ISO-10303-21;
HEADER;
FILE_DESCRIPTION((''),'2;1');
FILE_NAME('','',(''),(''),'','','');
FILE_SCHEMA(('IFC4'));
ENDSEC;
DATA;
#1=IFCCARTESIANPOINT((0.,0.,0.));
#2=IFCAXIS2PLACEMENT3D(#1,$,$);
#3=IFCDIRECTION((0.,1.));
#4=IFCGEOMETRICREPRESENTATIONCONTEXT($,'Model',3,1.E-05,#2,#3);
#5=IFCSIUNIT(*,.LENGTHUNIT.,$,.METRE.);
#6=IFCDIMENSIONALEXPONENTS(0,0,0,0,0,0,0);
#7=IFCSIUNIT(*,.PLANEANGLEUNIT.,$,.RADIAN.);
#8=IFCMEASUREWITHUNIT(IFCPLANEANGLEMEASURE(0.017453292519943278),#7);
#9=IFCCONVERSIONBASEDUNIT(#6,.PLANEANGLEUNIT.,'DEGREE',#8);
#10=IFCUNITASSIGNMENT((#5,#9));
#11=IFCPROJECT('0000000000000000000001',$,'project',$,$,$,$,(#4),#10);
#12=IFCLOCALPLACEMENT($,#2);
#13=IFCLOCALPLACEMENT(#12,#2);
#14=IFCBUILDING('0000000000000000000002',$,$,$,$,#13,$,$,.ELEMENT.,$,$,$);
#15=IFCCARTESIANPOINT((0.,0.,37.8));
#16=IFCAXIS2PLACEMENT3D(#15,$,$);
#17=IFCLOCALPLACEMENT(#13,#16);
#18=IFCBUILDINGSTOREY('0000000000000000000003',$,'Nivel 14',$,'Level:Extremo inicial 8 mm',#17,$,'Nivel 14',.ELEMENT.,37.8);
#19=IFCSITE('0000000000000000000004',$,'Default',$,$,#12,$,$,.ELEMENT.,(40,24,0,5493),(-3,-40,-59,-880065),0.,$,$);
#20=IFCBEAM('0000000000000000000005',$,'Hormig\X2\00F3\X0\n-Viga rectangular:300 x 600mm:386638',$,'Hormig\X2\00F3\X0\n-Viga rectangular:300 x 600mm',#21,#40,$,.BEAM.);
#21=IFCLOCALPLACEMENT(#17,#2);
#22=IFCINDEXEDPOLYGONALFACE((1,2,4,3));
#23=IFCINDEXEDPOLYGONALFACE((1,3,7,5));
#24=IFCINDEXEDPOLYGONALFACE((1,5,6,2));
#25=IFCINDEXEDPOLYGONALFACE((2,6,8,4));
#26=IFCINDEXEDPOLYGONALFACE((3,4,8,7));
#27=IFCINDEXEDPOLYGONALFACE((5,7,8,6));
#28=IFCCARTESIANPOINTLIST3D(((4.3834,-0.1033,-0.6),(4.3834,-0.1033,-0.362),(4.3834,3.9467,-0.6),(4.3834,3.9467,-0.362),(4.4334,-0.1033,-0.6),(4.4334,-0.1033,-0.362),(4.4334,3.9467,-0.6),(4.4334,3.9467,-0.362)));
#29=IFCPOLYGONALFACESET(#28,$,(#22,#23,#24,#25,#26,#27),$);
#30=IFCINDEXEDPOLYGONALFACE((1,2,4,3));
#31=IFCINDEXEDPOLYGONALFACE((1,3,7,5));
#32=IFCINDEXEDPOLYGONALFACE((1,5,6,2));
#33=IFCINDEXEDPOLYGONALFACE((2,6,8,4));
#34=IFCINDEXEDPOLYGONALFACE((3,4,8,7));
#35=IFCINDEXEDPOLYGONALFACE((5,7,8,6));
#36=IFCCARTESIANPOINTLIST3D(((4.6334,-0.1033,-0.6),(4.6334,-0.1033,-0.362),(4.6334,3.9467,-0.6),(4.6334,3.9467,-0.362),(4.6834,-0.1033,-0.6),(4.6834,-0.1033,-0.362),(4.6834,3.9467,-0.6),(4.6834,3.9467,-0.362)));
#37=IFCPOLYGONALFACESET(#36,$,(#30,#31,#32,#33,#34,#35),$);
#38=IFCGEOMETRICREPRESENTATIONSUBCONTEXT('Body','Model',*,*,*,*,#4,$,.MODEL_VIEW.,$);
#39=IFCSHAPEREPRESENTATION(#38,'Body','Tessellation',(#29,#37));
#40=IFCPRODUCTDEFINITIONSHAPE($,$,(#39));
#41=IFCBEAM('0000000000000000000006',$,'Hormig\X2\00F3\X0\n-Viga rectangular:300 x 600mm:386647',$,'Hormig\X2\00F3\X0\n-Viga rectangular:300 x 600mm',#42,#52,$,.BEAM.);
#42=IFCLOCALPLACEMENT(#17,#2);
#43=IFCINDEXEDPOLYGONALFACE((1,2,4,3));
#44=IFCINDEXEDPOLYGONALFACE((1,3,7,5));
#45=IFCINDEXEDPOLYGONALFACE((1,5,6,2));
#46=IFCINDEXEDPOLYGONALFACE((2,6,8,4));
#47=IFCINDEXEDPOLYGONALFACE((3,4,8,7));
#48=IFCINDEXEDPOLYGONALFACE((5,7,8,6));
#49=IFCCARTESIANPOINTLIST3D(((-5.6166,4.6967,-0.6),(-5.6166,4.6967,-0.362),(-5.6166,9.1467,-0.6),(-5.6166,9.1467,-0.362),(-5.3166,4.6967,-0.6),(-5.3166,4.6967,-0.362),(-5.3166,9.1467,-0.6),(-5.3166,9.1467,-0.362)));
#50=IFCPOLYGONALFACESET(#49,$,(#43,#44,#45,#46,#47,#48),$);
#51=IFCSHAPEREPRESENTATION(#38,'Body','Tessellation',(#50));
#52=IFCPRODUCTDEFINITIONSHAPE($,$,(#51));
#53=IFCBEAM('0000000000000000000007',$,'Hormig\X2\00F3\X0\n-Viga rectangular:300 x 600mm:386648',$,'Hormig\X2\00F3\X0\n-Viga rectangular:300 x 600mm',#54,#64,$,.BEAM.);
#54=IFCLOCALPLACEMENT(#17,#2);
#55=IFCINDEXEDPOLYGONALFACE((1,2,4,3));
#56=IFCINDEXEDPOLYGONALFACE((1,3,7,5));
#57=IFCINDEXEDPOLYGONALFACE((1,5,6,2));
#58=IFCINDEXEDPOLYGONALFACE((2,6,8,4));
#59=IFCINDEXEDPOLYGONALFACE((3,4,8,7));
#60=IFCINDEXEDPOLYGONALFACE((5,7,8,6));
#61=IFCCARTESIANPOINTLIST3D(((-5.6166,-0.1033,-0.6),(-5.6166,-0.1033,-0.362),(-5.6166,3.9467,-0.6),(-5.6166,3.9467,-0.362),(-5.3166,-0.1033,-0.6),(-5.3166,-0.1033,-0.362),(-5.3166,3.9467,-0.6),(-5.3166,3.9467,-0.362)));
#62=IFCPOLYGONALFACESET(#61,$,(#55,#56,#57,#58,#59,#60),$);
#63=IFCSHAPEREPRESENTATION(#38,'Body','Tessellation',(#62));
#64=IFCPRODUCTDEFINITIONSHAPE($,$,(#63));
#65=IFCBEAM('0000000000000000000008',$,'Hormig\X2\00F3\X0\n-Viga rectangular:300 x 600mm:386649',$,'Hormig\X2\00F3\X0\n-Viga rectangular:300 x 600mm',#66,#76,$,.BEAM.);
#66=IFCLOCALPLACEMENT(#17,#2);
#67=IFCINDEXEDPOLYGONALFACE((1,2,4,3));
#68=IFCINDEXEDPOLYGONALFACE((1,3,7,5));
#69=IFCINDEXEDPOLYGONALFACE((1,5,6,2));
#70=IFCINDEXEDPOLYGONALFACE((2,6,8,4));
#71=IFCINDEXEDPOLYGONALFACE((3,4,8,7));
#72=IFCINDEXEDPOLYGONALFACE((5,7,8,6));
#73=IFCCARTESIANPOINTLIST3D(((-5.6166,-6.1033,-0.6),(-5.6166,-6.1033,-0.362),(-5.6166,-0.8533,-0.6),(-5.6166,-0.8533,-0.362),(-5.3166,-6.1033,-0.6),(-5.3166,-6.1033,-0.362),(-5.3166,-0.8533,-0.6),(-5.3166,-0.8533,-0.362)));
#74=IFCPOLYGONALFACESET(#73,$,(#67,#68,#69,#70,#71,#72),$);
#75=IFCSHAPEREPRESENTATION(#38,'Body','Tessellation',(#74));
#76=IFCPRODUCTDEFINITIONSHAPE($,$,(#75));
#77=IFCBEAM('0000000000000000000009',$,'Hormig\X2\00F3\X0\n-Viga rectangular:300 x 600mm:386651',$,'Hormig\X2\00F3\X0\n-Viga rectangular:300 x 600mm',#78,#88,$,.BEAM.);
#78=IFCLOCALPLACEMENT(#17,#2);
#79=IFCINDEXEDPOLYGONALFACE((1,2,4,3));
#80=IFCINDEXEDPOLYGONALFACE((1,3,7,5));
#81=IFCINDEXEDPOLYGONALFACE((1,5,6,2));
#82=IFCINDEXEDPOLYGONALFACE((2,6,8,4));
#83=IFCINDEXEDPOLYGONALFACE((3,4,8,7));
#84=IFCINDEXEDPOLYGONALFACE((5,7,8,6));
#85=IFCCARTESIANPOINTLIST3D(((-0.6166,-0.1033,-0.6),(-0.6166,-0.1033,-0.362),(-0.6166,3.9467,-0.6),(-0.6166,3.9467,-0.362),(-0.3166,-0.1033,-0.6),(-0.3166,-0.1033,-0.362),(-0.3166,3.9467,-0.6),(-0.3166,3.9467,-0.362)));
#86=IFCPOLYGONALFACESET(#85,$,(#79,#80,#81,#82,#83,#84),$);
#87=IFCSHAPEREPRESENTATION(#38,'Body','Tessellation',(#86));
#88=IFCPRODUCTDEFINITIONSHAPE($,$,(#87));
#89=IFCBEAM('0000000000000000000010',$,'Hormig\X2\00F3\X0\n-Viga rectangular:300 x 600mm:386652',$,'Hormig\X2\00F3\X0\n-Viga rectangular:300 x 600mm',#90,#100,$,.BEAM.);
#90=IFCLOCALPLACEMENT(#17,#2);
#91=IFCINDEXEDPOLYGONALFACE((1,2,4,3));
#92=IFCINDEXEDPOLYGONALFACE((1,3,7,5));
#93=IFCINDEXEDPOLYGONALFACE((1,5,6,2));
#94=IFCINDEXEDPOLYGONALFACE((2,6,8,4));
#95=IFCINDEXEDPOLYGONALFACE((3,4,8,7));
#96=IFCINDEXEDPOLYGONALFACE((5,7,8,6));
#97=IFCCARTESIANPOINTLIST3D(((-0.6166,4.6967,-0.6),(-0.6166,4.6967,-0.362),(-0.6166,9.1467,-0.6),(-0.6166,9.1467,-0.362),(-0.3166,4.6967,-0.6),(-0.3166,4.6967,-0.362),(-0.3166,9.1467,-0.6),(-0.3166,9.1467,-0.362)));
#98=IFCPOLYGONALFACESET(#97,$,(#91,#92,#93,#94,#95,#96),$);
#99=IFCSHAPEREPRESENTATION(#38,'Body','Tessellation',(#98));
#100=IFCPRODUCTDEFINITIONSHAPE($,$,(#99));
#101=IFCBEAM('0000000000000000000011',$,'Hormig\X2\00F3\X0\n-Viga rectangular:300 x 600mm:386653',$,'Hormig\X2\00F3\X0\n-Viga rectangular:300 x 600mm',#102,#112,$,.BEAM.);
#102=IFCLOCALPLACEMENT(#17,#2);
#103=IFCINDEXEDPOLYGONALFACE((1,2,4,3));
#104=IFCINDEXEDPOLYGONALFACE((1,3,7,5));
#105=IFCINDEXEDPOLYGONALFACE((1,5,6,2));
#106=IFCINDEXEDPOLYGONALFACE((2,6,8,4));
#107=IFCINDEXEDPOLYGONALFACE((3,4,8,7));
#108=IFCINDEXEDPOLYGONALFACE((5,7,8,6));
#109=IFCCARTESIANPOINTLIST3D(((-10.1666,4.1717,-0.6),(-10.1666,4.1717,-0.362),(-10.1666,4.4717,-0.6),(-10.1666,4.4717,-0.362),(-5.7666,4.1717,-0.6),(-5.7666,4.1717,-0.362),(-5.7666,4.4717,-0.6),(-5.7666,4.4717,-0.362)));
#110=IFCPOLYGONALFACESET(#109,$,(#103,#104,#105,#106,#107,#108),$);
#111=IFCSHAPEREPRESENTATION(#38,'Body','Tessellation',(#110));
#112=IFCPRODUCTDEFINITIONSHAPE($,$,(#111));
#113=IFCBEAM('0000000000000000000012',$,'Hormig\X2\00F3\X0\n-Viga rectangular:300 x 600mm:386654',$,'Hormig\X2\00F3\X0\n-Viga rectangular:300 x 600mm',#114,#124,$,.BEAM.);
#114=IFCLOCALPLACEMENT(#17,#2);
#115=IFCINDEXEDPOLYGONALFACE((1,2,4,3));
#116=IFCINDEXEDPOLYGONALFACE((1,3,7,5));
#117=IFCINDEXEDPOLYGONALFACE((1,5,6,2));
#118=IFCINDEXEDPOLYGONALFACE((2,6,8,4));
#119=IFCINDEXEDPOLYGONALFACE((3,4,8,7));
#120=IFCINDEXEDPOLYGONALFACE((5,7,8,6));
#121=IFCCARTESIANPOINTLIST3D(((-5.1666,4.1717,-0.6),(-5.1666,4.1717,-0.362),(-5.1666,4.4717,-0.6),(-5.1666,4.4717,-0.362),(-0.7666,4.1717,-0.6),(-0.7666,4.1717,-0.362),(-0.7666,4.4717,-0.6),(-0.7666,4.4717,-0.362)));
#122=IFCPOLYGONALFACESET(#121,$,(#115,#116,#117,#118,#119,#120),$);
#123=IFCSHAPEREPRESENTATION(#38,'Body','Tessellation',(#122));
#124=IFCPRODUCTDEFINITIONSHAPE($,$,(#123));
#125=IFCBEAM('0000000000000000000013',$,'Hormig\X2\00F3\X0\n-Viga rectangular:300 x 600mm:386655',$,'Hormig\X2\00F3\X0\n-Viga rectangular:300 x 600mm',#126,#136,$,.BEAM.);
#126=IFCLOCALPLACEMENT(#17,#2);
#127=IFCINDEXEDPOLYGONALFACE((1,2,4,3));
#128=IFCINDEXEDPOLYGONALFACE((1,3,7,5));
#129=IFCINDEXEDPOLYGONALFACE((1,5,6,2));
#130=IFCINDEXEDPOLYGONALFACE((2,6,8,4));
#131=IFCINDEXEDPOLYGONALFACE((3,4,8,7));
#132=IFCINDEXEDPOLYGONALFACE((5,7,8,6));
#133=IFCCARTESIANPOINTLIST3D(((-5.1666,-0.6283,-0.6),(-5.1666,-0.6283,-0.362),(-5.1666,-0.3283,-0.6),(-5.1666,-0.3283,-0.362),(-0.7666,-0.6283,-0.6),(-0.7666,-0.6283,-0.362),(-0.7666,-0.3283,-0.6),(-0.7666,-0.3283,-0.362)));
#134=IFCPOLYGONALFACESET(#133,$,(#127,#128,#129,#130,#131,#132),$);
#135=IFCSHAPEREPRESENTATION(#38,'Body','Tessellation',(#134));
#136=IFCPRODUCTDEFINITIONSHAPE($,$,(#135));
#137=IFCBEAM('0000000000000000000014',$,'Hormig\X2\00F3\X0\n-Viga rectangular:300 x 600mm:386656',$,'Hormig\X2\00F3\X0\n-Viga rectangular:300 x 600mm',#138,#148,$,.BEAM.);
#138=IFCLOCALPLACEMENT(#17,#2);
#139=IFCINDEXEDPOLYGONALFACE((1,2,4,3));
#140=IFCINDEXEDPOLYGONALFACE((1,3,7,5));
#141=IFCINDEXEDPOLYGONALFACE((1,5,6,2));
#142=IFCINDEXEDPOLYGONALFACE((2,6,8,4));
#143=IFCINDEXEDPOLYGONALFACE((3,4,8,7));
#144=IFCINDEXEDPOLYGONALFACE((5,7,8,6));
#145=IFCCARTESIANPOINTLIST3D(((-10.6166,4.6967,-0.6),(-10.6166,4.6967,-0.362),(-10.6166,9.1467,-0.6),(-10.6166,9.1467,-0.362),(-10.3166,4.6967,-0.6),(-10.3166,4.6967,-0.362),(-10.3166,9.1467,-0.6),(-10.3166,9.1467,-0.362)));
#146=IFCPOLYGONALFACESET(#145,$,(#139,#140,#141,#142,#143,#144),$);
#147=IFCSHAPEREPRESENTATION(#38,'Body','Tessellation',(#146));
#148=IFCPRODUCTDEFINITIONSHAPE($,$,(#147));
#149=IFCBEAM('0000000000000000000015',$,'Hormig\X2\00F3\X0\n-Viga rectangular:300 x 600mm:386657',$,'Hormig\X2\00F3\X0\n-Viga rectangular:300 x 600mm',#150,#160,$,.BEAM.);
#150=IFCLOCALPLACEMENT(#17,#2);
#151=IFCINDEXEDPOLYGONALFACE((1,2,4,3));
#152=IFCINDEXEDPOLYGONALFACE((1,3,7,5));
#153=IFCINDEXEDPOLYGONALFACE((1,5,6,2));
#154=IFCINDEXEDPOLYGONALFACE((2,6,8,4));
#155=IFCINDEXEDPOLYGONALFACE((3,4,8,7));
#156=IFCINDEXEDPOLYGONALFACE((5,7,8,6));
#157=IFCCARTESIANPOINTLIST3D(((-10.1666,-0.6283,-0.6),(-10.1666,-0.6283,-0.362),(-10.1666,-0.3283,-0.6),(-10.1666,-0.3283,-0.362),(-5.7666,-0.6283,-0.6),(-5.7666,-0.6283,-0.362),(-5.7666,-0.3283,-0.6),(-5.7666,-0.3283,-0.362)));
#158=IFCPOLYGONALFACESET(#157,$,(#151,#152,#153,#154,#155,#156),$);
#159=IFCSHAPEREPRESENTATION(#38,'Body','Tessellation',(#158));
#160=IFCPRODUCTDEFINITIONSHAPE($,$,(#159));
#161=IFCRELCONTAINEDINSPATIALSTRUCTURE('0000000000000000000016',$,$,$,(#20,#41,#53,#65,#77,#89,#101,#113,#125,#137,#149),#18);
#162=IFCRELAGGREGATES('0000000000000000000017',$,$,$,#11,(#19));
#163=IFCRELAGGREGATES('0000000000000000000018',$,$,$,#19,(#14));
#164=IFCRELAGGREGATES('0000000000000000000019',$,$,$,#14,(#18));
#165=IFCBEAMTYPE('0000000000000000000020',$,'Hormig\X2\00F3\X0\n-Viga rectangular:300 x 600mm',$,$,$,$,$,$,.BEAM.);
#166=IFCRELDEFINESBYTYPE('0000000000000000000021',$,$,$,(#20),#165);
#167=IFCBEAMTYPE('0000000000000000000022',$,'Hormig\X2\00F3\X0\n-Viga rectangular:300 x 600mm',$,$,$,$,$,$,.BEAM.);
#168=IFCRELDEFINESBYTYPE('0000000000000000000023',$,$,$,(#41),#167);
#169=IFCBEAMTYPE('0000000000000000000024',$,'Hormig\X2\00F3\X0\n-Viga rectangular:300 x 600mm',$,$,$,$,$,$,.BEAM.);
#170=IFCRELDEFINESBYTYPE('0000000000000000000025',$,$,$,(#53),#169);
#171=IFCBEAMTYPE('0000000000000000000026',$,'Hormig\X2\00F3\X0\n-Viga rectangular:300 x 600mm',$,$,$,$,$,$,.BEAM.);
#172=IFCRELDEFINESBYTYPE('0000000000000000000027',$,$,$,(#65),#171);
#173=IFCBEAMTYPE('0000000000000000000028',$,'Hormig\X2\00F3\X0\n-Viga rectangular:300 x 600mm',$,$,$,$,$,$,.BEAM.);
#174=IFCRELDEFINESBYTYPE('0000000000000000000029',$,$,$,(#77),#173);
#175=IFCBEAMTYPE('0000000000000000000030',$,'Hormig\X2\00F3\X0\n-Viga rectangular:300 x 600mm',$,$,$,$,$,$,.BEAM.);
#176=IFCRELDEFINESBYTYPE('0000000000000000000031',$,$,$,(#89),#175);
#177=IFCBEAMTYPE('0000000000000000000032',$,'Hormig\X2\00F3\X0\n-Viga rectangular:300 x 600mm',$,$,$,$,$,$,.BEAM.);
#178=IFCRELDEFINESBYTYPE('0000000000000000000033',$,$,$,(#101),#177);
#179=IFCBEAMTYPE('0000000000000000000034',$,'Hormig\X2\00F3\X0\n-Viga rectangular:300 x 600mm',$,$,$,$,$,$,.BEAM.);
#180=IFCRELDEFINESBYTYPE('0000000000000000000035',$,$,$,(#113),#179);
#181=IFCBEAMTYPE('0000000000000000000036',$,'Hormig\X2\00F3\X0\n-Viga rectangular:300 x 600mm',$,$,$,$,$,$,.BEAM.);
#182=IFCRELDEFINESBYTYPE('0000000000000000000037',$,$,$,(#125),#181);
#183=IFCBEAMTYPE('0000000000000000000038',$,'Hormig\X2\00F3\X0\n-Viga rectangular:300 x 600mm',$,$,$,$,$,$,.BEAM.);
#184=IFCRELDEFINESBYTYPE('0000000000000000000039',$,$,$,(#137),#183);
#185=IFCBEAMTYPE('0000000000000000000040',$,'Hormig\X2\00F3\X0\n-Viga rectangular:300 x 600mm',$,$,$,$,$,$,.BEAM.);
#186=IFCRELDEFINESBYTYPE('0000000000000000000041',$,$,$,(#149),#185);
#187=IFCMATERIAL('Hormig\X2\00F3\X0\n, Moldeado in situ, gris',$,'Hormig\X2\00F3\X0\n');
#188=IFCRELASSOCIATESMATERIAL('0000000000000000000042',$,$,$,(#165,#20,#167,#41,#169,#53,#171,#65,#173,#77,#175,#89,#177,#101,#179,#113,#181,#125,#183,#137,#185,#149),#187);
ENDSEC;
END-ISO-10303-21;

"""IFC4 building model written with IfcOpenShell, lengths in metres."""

from ifc_helpers import new_model, entity, si_unit, converted_unit, direction, frame, origin, place, context, subcontext, project, spatial, indexed_curve, outline, extrude, source, transform, mapped, material, type_object, type_shapes, element, save


model = new_model("IFC4")

# Units and contexts
model_context = context("Model", 3, precision=1e-05, world=origin(), true_north=direction((0.0, 1.0)))
body_context = subcontext(model_context, "Body", "Model", "MODEL_VIEW")
ifc_project = project(units=[si_unit("LENGTHUNIT", "METRE"), converted_unit("PLANEANGLEUNIT", "DEGREE", entity("IfcPlaneAngleMeasure", 0.017453292519943278), si_unit("PLANEANGLEUNIT", "RADIAN"), dimensions=[0, 0, 0, 0, 0, 0, 0])], contexts=[model_context])

# Site, building, storey
site_placement = place(None, origin())
site = spatial("IfcSite", under=ifc_project, at=site_placement, Name="Default", CompositionType="ELEMENT", RefLatitude=(40, 24, 0, 5493), RefLongitude=(-3, -40, -59, -880065), RefElevation=0.0)
building_placement = place(site_placement, origin())
building = spatial("IfcBuilding", under=site, at=building_placement, CompositionType="ELEMENT")
storey_placement = place(building_placement, frame((0.0, 0.0, 37.8)))
storey = spatial("IfcBuildingStorey", under=building, at=storey_placement, Name="Nivel 14", ObjectType="Level:Extremo inicial 8 mm", LongName="Nivel 14", CompositionType="ELEMENT", Elevation=37.8)

# Shared definitions
ifc_material_1 = material(Name="Hormigón, Moldeado in situ, gris", Category="Hormigón")

# Beams
beam_type_1 = type_object("IfcBeamType", Name="Hormigón-Viga rectangular:300 x 600mm", PredefinedType="BEAM", material=ifc_material_1)
shared_shape_1 = source(origin(), body_context, "Body", "SweptSolid", [
    extrude(outline(indexed_curve([(-0.025, -0.119), (0.025, -0.119), (0.025, 0.119), (-0.025, 0.119), (-0.025, -0.119)], self_intersect=False)), frame((4.4084, 3.9467, 37.319), z_axis=(0.0, -1.0, 0.0), x_axis=(-1.0, 0.0, 0.0)), (0.0, 0.0, 1.0), 4.05),
    extrude(outline(indexed_curve([(-0.025, -0.119), (0.025, -0.119), (0.025, 0.119), (-0.025, 0.119), (-0.025, -0.119)], self_intersect=False)), frame((4.6584, 3.9467, 37.319), z_axis=(0.0, -1.0, 0.0), x_axis=(-1.0, 0.0, 0.0)), (0.0, 0.0, 1.0), 4.05),
])
type_shapes(beam_type_1, [shared_shape_1])
beam_1_placement = place(storey_placement, frame((0.0, 0.0, -37.8)))
element("IfcBeam", 1, at=beam_1_placement, inside=storey, type_object=beam_type_1, material=ifc_material_1, Name="Hormigón-Viga rectangular:300 x 600mm:386638", ObjectType="Hormigón-Viga rectangular:300 x 600mm", PredefinedType="BEAM", context=body_context, shape_type="MappedRepresentation", body=[
    mapped(shared_shape_1, transform((0.0, 0.0, 0.0), scale=1.0)),
])
beam_type_2 = type_object("IfcBeamType", Name="Hormigón-Viga rectangular:300 x 600mm", PredefinedType="BEAM", material=ifc_material_1)
shared_shape_2 = source(origin(), body_context, "Body", "SweptSolid", [
    extrude(outline(indexed_curve([(-0.15, -0.119), (0.15, -0.119), (0.15, 0.119), (-0.15, 0.119), (-0.15, -0.119)], self_intersect=False)), frame((-5.4666, 9.1467, 37.319), z_axis=(0.0, -1.0, 0.0), x_axis=(-1.0, 0.0, 0.0)), (0.0, 0.0, 1.0), 4.45),
])
type_shapes(beam_type_2, [shared_shape_2])
beam_2_placement = place(storey_placement, frame((0.0, 0.0, -37.8)))
element("IfcBeam", 2, at=beam_2_placement, inside=storey, type_object=beam_type_2, material=ifc_material_1, Name="Hormigón-Viga rectangular:300 x 600mm:386647", ObjectType="Hormigón-Viga rectangular:300 x 600mm", PredefinedType="BEAM", context=body_context, shape_type="MappedRepresentation", body=[
    mapped(shared_shape_2, transform((0.0, 0.0, 0.0), scale=1.0)),
])
beam_type_3 = type_object("IfcBeamType", Name="Hormigón-Viga rectangular:300 x 600mm", PredefinedType="BEAM", material=ifc_material_1)
shared_shape_3 = source(origin(), body_context, "Body", "SweptSolid", [
    extrude(outline(indexed_curve([(-0.15, -0.119), (0.15, -0.119), (0.15, 0.119), (-0.15, 0.119), (-0.15, -0.119)], self_intersect=False)), frame((-5.4666, 3.9467, 37.319), z_axis=(0.0, -1.0, 0.0), x_axis=(-1.0, 0.0, 0.0)), (0.0, 0.0, 1.0), 4.05),
])
type_shapes(beam_type_3, [shared_shape_3])
beam_3_placement = place(storey_placement, frame((0.0, 0.0, -37.8)))
element("IfcBeam", 3, at=beam_3_placement, inside=storey, type_object=beam_type_3, material=ifc_material_1, Name="Hormigón-Viga rectangular:300 x 600mm:386648", ObjectType="Hormigón-Viga rectangular:300 x 600mm", PredefinedType="BEAM", context=body_context, shape_type="MappedRepresentation", body=[
    mapped(shared_shape_3, transform((0.0, 0.0, 0.0), scale=1.0)),
])
beam_type_4 = type_object("IfcBeamType", Name="Hormigón-Viga rectangular:300 x 600mm", PredefinedType="BEAM", material=ifc_material_1)
shared_shape_4 = source(origin(), body_context, "Body", "SweptSolid", [
    extrude(outline(indexed_curve([(-0.15, -0.119), (0.15, -0.119), (0.15, 0.119), (-0.15, 0.119), (-0.15, -0.119)], self_intersect=False)), frame((-5.4666, -6.1033, 37.319), z_axis=(0.0, 1.0, 0.0), x_axis=(-1.0, 0.0, 0.0)), (0.0, 0.0, 1.0), 5.25),
])
type_shapes(beam_type_4, [shared_shape_4])
beam_4_placement = place(storey_placement, frame((0.0, 0.0, -37.8)))
element("IfcBeam", 4, at=beam_4_placement, inside=storey, type_object=beam_type_4, material=ifc_material_1, Name="Hormigón-Viga rectangular:300 x 600mm:386649", ObjectType="Hormigón-Viga rectangular:300 x 600mm", PredefinedType="BEAM", context=body_context, shape_type="MappedRepresentation", body=[
    mapped(shared_shape_4, transform((0.0, 0.0, 0.0), scale=1.0)),
])
beam_type_5 = type_object("IfcBeamType", Name="Hormigón-Viga rectangular:300 x 600mm", PredefinedType="BEAM", material=ifc_material_1)
shared_shape_5 = source(origin(), body_context, "Body", "SweptSolid", [
    extrude(outline(indexed_curve([(-0.15, -0.119), (0.15, -0.119), (0.15, 0.119), (-0.15, 0.119), (-0.15, -0.119)], self_intersect=False)), frame((-0.4666, -0.1033, 37.319), z_axis=(0.0, 1.0, 0.0), x_axis=(-1.0, 0.0, 0.0)), (0.0, 0.0, 1.0), 4.05),
])
type_shapes(beam_type_5, [shared_shape_5])
beam_5_placement = place(storey_placement, frame((0.0, 0.0, -37.8)))
element("IfcBeam", 5, at=beam_5_placement, inside=storey, type_object=beam_type_5, material=ifc_material_1, Name="Hormigón-Viga rectangular:300 x 600mm:386651", ObjectType="Hormigón-Viga rectangular:300 x 600mm", PredefinedType="BEAM", context=body_context, shape_type="MappedRepresentation", body=[
    mapped(shared_shape_5, transform((0.0, 0.0, 0.0), scale=1.0)),
])
beam_type_6 = type_object("IfcBeamType", Name="Hormigón-Viga rectangular:300 x 600mm", PredefinedType="BEAM", material=ifc_material_1)
shared_shape_6 = source(origin(), body_context, "Body", "SweptSolid", [
    extrude(outline(indexed_curve([(-0.15, -0.119), (0.15, -0.119), (0.15, 0.119), (-0.15, 0.119), (-0.15, -0.119)], self_intersect=False)), frame((-0.4666, 9.1467, 37.319), z_axis=(0.0, -1.0, 0.0), x_axis=(-1.0, 0.0, 0.0)), (0.0, 0.0, 1.0), 4.45),
])
type_shapes(beam_type_6, [shared_shape_6])
beam_6_placement = place(storey_placement, frame((0.0, 0.0, -37.8)))
element("IfcBeam", 6, at=beam_6_placement, inside=storey, type_object=beam_type_6, material=ifc_material_1, Name="Hormigón-Viga rectangular:300 x 600mm:386652", ObjectType="Hormigón-Viga rectangular:300 x 600mm", PredefinedType="BEAM", context=body_context, shape_type="MappedRepresentation", body=[
    mapped(shared_shape_6, transform((0.0, 0.0, 0.0), scale=1.0)),
])
beam_type_7 = type_object("IfcBeamType", Name="Hormigón-Viga rectangular:300 x 600mm", PredefinedType="BEAM", material=ifc_material_1)
shared_shape_7 = source(origin(), body_context, "Body", "SweptSolid", [
    extrude(outline(indexed_curve([(-0.119, -0.15), (0.119, -0.15), (0.119, 0.15), (-0.119, 0.15), (-0.119, -0.15)], self_intersect=False)), frame((-10.1666, 4.3217, 37.319), z_axis=(1.0, 0.0, 0.0), x_axis=(0.0, 0.0, -1.0)), (0.0, 0.0, 1.0), 4.4),
])
type_shapes(beam_type_7, [shared_shape_7])
beam_7_placement = place(storey_placement, frame((0.0, 0.0, -37.8)))
element("IfcBeam", 7, at=beam_7_placement, inside=storey, type_object=beam_type_7, material=ifc_material_1, Name="Hormigón-Viga rectangular:300 x 600mm:386653", ObjectType="Hormigón-Viga rectangular:300 x 600mm", PredefinedType="BEAM", context=body_context, shape_type="MappedRepresentation", body=[
    mapped(shared_shape_7, transform((0.0, 0.0, 0.0), scale=1.0)),
])
beam_type_8 = type_object("IfcBeamType", Name="Hormigón-Viga rectangular:300 x 600mm", PredefinedType="BEAM", material=ifc_material_1)
shared_shape_8 = source(origin(), body_context, "Body", "SweptSolid", [
    extrude(outline(indexed_curve([(-0.119, -0.15), (0.119, -0.15), (0.119, 0.15), (-0.119, 0.15), (-0.119, -0.15)], self_intersect=False)), frame((-5.1666, 4.3217, 37.319), z_axis=(1.0, 0.0, 0.0), x_axis=(0.0, 0.0, -1.0)), (0.0, 0.0, 1.0), 4.4),
])
type_shapes(beam_type_8, [shared_shape_8])
beam_8_placement = place(storey_placement, frame((0.0, 0.0, -37.8)))
element("IfcBeam", 8, at=beam_8_placement, inside=storey, type_object=beam_type_8, material=ifc_material_1, Name="Hormigón-Viga rectangular:300 x 600mm:386654", ObjectType="Hormigón-Viga rectangular:300 x 600mm", PredefinedType="BEAM", context=body_context, shape_type="MappedRepresentation", body=[
    mapped(shared_shape_8, transform((0.0, 0.0, 0.0), scale=1.0)),
])
beam_type_9 = type_object("IfcBeamType", Name="Hormigón-Viga rectangular:300 x 600mm", PredefinedType="BEAM", material=ifc_material_1)
shared_shape_9 = source(origin(), body_context, "Body", "SweptSolid", [
    extrude(outline(indexed_curve([(-0.119, -0.15), (0.119, -0.15), (0.119, 0.15), (-0.119, 0.15), (-0.119, -0.15)], self_intersect=False)), frame((-0.7666, -0.4783, 37.319), z_axis=(-1.0, 0.0, 0.0), x_axis=(0.0, 0.0, -1.0)), (0.0, 0.0, 1.0), 4.4),
])
type_shapes(beam_type_9, [shared_shape_9])
beam_9_placement = place(storey_placement, frame((0.0, 0.0, -37.8)))
element("IfcBeam", 9, at=beam_9_placement, inside=storey, type_object=beam_type_9, material=ifc_material_1, Name="Hormigón-Viga rectangular:300 x 600mm:386655", ObjectType="Hormigón-Viga rectangular:300 x 600mm", PredefinedType="BEAM", context=body_context, shape_type="MappedRepresentation", body=[
    mapped(shared_shape_9, transform((0.0, 0.0, 0.0), scale=1.0)),
])
beam_type_10 = type_object("IfcBeamType", Name="Hormigón-Viga rectangular:300 x 600mm", PredefinedType="BEAM", material=ifc_material_1)
shared_shape_10 = source(origin(), body_context, "Body", "SweptSolid", [
    extrude(outline(indexed_curve([(-0.15, -0.119), (0.15, -0.119), (0.15, 0.119), (-0.15, 0.119), (-0.15, -0.119)], self_intersect=False)), frame((-10.4666, 4.6967, 37.319), z_axis=(0.0, 1.0, 0.0), x_axis=(-1.0, 0.0, 0.0)), (0.0, 0.0, 1.0), 4.45),
])
type_shapes(beam_type_10, [shared_shape_10])
beam_10_placement = place(storey_placement, frame((0.0, 0.0, -37.8)))
element("IfcBeam", 10, at=beam_10_placement, inside=storey, type_object=beam_type_10, material=ifc_material_1, Name="Hormigón-Viga rectangular:300 x 600mm:386656", ObjectType="Hormigón-Viga rectangular:300 x 600mm", PredefinedType="BEAM", context=body_context, shape_type="MappedRepresentation", body=[
    mapped(shared_shape_10, transform((0.0, 0.0, 0.0), scale=1.0)),
])
beam_type_11 = type_object("IfcBeamType", Name="Hormigón-Viga rectangular:300 x 600mm", PredefinedType="BEAM", material=ifc_material_1)
shared_shape_11 = source(origin(), body_context, "Body", "SweptSolid", [
    extrude(outline(indexed_curve([(-0.119, -0.15), (0.119, -0.15), (0.119, 0.15), (-0.119, 0.15), (-0.119, -0.15)], self_intersect=False)), frame((-10.1666, -0.4783, 37.319), z_axis=(1.0, 0.0, 0.0), x_axis=(0.0, 0.0, -1.0)), (0.0, 0.0, 1.0), 4.4),
])
type_shapes(beam_type_11, [shared_shape_11])
beam_11_placement = place(storey_placement, frame((0.0, 0.0, -37.8)))
element("IfcBeam", 11, at=beam_11_placement, inside=storey, type_object=beam_type_11, material=ifc_material_1, Name="Hormigón-Viga rectangular:300 x 600mm:386657", ObjectType="Hormigón-Viga rectangular:300 x 600mm", PredefinedType="BEAM", context=body_context, shape_type="MappedRepresentation", body=[
    mapped(shared_shape_11, transform((0.0, 0.0, 0.0), scale=1.0)),
])

save(model, "model.ifc")
